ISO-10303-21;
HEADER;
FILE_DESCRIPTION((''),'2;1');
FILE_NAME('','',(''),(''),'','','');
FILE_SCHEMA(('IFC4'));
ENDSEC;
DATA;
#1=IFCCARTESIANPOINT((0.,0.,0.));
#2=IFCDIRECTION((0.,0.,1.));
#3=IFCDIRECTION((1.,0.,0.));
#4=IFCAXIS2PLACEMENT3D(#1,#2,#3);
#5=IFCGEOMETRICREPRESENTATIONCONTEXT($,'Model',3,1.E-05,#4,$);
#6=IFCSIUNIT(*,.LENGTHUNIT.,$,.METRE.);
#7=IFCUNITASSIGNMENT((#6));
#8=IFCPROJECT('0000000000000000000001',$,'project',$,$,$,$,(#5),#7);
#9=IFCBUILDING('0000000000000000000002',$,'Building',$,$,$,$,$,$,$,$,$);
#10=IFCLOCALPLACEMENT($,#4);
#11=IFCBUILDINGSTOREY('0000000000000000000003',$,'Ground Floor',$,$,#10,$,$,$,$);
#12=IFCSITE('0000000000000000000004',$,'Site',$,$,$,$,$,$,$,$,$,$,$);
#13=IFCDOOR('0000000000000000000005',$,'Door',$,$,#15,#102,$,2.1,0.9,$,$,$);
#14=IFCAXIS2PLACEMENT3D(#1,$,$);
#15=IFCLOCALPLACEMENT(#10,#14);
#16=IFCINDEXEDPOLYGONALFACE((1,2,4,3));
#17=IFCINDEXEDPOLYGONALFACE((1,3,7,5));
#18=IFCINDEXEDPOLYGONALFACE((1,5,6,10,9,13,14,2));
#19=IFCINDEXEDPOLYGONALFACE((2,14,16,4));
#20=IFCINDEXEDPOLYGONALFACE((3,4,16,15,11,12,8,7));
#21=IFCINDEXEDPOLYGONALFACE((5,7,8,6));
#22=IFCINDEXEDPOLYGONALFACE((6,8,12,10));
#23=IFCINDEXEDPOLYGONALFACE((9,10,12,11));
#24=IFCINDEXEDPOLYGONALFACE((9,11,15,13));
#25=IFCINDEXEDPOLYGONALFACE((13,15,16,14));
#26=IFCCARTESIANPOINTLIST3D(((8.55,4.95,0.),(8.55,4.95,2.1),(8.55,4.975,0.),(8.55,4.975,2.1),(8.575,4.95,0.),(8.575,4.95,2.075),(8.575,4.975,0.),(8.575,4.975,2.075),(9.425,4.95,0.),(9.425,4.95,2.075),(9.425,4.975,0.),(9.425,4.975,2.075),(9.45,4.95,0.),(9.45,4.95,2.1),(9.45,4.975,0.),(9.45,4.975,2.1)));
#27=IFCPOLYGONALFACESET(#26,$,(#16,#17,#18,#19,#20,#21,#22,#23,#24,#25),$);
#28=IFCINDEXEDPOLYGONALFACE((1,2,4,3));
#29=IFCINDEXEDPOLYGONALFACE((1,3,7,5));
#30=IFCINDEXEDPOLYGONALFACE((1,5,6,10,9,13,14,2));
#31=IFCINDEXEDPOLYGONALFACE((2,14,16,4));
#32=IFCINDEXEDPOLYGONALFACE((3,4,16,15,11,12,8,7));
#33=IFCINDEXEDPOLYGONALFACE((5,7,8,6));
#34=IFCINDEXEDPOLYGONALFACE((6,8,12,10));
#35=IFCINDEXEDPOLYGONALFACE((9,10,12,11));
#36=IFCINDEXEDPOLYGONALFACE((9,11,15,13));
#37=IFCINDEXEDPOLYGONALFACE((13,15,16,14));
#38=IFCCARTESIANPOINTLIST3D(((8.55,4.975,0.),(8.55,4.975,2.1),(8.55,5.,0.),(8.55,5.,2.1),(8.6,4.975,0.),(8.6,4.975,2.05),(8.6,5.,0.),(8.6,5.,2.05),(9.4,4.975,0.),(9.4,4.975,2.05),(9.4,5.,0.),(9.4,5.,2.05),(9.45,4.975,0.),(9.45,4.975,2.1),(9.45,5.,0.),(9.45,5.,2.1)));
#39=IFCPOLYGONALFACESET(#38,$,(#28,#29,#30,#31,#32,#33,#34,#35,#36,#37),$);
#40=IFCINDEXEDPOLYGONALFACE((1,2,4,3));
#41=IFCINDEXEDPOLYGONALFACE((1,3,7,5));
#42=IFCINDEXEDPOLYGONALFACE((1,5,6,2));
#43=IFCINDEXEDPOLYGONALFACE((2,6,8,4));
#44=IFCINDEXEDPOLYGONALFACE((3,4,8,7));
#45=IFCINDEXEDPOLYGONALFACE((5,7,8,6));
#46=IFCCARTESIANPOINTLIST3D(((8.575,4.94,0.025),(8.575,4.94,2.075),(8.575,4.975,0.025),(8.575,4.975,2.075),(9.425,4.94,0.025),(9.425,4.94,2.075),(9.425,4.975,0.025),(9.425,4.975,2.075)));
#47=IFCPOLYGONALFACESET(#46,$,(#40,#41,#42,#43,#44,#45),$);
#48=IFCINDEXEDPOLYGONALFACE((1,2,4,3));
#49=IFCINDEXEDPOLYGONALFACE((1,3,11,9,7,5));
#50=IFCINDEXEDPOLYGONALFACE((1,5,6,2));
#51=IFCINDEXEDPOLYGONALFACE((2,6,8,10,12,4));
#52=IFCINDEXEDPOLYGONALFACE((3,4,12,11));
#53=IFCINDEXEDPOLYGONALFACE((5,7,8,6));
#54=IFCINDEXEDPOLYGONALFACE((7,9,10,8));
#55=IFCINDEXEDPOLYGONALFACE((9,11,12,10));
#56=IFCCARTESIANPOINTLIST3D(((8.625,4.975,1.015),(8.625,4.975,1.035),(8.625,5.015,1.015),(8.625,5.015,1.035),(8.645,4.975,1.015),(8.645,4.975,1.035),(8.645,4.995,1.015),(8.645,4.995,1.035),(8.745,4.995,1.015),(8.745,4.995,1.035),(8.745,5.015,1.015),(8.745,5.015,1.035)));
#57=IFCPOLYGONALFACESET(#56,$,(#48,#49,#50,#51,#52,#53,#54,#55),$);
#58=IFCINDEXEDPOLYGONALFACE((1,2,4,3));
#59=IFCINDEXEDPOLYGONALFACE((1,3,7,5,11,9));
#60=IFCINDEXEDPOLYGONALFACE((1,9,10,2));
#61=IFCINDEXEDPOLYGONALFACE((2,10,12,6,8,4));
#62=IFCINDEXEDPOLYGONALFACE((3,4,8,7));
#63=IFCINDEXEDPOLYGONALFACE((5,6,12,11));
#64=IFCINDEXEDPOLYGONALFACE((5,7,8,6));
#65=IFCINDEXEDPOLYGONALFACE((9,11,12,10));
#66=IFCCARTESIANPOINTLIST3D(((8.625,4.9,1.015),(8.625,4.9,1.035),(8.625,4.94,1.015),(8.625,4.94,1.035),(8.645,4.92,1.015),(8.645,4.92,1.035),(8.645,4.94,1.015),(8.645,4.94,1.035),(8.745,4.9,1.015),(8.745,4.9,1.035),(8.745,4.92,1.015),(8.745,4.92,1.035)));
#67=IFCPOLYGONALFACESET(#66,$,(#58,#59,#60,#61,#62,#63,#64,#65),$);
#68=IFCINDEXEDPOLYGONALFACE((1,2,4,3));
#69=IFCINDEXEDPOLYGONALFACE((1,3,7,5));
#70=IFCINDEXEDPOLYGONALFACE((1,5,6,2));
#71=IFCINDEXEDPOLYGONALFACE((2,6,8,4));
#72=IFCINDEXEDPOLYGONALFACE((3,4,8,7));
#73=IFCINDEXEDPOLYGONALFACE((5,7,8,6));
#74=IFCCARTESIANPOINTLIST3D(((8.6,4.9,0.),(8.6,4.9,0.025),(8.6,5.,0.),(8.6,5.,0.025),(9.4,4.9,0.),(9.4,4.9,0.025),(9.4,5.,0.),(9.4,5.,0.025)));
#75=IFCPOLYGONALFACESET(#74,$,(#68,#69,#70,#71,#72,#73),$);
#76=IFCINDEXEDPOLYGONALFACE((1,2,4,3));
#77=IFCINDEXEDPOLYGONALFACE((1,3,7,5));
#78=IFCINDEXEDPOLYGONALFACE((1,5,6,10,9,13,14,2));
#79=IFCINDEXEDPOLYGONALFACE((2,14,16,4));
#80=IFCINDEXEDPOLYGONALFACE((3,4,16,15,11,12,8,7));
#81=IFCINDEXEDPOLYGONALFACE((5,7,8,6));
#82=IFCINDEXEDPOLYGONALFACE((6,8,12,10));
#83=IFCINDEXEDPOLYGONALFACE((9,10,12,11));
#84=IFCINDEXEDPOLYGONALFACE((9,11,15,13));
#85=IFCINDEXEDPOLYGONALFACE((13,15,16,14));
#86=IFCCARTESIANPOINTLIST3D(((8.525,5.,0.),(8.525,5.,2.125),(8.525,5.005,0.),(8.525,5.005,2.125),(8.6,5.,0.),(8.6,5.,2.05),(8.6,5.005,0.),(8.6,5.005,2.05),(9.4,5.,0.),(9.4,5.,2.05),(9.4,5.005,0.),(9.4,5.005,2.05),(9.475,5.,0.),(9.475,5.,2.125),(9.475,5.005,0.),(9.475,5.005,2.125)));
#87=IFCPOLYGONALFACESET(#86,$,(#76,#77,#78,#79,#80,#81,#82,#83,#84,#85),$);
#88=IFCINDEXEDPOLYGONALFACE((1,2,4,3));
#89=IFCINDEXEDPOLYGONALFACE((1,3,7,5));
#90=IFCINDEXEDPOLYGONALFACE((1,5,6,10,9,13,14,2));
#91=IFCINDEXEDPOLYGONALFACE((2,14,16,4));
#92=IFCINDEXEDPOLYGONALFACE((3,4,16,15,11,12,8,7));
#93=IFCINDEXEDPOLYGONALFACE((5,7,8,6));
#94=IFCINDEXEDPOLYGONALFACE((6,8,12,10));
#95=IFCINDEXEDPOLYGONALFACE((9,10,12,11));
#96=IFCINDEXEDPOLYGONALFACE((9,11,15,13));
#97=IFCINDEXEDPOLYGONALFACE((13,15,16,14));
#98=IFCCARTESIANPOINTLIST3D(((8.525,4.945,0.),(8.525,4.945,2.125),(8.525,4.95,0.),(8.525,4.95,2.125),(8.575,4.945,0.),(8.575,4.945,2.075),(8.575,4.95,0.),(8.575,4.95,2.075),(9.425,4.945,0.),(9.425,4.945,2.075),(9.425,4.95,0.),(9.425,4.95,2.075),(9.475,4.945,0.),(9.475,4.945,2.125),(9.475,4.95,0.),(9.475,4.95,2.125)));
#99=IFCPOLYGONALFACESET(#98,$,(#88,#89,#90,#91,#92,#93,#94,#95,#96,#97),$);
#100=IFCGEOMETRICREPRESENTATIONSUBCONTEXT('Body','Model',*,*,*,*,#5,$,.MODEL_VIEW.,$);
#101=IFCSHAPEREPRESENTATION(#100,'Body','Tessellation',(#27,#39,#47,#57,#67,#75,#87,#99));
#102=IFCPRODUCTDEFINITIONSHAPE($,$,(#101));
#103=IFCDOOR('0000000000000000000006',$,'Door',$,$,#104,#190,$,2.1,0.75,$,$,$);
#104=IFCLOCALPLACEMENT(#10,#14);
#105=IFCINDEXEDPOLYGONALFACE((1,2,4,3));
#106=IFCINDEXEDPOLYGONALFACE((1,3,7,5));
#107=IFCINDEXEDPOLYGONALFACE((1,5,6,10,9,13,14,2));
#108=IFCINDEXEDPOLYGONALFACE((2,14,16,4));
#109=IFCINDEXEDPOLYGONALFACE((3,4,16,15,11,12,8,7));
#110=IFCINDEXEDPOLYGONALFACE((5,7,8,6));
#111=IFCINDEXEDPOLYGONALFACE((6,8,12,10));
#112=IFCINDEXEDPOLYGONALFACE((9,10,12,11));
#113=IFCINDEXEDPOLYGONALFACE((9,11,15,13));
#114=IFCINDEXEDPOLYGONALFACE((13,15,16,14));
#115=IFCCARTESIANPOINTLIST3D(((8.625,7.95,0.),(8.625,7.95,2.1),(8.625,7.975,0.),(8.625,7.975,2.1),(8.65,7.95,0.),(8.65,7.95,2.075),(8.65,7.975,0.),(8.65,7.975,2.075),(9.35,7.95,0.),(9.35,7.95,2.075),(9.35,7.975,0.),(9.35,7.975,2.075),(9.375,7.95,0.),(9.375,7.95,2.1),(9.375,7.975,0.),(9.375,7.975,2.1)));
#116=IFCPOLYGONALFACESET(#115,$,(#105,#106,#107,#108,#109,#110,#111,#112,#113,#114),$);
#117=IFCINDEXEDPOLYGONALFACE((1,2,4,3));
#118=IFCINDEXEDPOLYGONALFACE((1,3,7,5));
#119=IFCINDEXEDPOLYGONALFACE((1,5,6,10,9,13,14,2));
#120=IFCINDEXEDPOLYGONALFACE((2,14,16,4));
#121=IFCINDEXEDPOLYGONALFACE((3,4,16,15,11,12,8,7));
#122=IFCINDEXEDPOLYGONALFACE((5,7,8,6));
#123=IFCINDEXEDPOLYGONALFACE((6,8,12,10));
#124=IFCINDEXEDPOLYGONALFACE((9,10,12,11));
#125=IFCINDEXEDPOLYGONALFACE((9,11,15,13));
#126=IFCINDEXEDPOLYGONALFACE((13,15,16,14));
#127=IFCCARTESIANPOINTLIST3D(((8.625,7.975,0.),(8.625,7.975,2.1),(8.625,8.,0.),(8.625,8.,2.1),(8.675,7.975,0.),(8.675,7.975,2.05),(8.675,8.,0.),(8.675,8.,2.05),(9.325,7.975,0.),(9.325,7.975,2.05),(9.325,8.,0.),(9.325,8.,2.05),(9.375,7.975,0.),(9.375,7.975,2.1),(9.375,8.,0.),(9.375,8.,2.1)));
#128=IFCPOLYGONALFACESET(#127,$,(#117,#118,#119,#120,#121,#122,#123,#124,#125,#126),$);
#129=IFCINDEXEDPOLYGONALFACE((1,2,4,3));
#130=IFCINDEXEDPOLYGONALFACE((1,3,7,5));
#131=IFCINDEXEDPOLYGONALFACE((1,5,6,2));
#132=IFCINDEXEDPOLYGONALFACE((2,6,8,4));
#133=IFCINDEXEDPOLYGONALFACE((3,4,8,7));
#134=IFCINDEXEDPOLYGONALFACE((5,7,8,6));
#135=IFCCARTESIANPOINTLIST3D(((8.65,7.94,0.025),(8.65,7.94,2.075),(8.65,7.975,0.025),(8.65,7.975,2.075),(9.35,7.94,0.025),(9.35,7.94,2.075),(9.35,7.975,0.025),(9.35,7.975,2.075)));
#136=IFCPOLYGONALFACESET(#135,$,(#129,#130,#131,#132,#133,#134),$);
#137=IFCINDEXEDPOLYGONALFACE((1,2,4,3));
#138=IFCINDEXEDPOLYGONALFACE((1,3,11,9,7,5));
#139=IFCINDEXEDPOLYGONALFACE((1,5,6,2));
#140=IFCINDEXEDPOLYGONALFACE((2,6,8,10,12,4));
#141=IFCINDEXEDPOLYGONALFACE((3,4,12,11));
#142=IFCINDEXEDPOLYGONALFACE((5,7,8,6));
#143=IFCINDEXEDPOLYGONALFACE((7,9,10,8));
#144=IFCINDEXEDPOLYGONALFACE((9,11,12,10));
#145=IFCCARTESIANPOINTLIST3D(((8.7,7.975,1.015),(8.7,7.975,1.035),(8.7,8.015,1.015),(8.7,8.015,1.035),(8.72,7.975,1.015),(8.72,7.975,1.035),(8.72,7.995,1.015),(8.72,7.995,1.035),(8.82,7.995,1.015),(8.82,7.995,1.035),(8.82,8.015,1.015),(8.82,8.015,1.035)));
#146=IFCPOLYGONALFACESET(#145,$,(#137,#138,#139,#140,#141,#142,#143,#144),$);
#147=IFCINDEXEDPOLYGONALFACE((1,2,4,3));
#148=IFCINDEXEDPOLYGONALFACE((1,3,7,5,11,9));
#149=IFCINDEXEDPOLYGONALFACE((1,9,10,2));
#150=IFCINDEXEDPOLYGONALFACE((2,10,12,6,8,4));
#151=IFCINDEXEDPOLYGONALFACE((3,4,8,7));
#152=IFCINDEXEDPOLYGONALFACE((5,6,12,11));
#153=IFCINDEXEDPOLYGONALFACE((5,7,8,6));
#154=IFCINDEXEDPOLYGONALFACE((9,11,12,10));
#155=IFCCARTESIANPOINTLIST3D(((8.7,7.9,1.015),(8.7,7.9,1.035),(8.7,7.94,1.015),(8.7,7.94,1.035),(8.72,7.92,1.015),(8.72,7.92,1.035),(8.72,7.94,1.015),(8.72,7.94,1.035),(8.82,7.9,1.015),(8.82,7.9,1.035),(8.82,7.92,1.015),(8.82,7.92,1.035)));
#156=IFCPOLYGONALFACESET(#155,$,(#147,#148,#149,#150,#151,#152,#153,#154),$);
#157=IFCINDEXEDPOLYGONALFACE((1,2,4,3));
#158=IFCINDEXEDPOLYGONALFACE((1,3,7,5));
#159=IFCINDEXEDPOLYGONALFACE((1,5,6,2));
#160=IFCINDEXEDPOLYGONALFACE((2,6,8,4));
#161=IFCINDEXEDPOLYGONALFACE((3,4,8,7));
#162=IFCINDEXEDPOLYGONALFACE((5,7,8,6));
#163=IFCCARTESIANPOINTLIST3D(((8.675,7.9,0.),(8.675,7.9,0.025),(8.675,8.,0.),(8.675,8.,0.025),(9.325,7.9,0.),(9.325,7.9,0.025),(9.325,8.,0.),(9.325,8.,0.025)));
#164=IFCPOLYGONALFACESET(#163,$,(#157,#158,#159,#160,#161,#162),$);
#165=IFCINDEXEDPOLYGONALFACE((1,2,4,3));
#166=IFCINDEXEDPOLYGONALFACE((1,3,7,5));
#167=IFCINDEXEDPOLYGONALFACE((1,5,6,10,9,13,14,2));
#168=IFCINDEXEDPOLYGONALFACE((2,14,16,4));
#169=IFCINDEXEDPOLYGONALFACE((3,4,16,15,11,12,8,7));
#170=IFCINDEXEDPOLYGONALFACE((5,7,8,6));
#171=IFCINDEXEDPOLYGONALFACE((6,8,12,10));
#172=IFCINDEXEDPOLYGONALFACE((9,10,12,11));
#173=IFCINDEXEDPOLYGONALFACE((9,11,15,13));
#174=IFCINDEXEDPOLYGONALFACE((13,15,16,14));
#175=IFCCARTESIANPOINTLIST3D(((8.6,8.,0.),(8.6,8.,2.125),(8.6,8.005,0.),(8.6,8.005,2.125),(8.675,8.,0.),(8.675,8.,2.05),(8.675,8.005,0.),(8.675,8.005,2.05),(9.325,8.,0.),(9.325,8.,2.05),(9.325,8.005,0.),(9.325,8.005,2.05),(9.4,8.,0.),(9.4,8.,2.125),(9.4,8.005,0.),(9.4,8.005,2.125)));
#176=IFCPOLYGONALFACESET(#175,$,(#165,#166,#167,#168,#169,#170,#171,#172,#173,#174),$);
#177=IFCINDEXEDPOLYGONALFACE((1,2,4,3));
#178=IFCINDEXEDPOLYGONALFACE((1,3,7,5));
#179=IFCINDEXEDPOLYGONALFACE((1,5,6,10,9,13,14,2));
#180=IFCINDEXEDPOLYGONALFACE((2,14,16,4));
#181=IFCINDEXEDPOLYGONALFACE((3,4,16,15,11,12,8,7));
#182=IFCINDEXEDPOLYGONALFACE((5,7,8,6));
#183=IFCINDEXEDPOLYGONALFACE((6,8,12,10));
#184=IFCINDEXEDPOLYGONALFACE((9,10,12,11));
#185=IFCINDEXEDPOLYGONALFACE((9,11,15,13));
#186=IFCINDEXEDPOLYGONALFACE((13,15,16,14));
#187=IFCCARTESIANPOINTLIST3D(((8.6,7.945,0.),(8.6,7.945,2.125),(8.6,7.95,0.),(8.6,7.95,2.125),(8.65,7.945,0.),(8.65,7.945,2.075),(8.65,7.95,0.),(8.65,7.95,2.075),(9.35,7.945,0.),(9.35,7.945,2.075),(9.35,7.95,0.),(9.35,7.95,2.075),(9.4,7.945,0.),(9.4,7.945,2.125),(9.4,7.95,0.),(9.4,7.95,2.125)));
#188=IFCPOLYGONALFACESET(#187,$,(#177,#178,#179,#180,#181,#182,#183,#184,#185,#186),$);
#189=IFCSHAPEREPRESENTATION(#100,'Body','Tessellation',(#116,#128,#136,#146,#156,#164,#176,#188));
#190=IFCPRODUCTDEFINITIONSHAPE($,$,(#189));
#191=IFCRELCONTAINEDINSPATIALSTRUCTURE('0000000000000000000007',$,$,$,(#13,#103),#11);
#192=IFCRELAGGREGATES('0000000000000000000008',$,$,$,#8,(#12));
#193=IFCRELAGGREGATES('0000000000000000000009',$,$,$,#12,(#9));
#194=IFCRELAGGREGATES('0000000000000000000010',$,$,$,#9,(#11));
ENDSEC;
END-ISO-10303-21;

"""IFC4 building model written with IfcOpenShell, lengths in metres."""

from ifc_helpers import new_model, si_unit, frame, origin_with_axes, place, context, subcontext, project, spatial, line, indexed_curve, outline, extrude, element, save


model = new_model("IFC4")

# Units and contexts
model_context = context("Model", 3, precision=1e-05, world=origin_with_axes())
body_context = subcontext(model_context, "Body", "Model", "MODEL_VIEW")
ifc_project = project(units=[si_unit("LENGTHUNIT", "METRE")], contexts=[model_context])

# Site, building, storey
site = spatial("IfcSite", under=ifc_project, Name="Site")
building = spatial("IfcBuilding", under=site, Name="Building")
storey_placement = place(None, origin_with_axes())
storey = spatial("IfcBuildingStorey", under=building, at=storey_placement, Name="Ground Floor")

# Doors
door_1_placement = place(storey_placement, frame((9.45, 5.0, 0.0), z_axis=(0.0, 0.0, 1.0), x_axis=(-1.0, 0.0, 0.0)))
element("IfcDoor", 1, at=door_1_placement, inside=storey, Name="Door", OverallHeight=2.1, OverallWidth=0.9, context=body_context, shape_type="SweptSolid", body=[
    extrude(outline(indexed_curve([(0.0, 0.0), (0.0, 2.1), (0.9, 2.1), (0.9, 0.0), (0.875, 0.0), (0.875, 2.075), (0.025, 2.075), (0.025, 0.0)], segments=[line(1, 2, 3, 4, 5, 6, 7, 8, 1)])), frame((0.0, 0.025, 0.0), z_axis=(0.0, -1.0, 0.0), x_axis=(1.0, 0.0, 0.0)), (0.0, 0.0, -1.0), 0.025),
    extrude(outline(indexed_curve([(0.0, 0.0), (0.0, 2.1), (0.9, 2.1), (0.9, 0.0), (0.85, 0.0), (0.85, 2.05), (0.05, 2.05), (0.05, 0.0)], segments=[line(1, 2, 3, 4, 5, 6, 7, 8, 1)])), frame((0.0, 0.0, 0.0), z_axis=(0.0, -1.0, 0.0), x_axis=(1.0, 0.0, 0.0)), (0.0, 0.0, -1.0), 0.025),
    extrude(outline(indexed_curve([(0.0, 0.0), (0.85, 0.0), (0.85, 0.035), (0.0, 0.035)], segments=[line(1, 2, 3, 4, 1)])), frame((0.025, 0.025, 0.025), z_axis=(0.0, 0.0, 1.0), x_axis=(1.0, 0.0, 0.0)), (0.0, 0.0, 1.0), 2.05),
    extrude(outline(indexed_curve([(0.0, 0.0), (0.0, -0.04), (-0.12, -0.04), (-0.12, -0.02), (-0.02, -0.02), (-0.02, 0.0)], segments=[line(1, 2, 3, 4, 5, 6, 1)])), frame((0.825, 0.025, 1.015), z_axis=(0.0, 0.0, 1.0), x_axis=(1.0, 0.0, 0.0)), (0.0, 0.0, 1.0), 0.02),
    extrude(outline(indexed_curve([(0.0, 0.0), (0.0, 0.04), (-0.12, 0.04), (-0.12, 0.02), (-0.02, 0.02), (-0.02, 0.0)], segments=[line(1, 2, 3, 4, 5, 6, 1)])), frame((0.825, 0.06, 1.015), z_axis=(0.0, 0.0, 1.0), x_axis=(1.0, 0.0, 0.0)), (0.0, 0.0, 1.0), 0.02),
    extrude(outline(indexed_curve([(0.0, 0.0), (0.8, 0.0), (0.8, 0.1), (0.0, 0.1)], segments=[line(1, 2, 3, 4, 1)])), frame((0.05, 0.0, 0.0), z_axis=(0.0, 0.0, 1.0), x_axis=(1.0, 0.0, 0.0)), (0.0, 0.0, 1.0), 0.025),
    extrude(outline(indexed_curve([(0.0, 0.0), (0.0, 2.125), (0.95, 2.125), (0.95, 0.0), (0.875, 0.0), (0.875, 2.05), (0.075, 2.05), (0.075, 0.0)], segments=[line(1, 2, 3, 4, 5, 6, 7, 8, 1)])), frame((-0.025, -0.005, 0.0), z_axis=(0.0, -1.0, 0.0), x_axis=(1.0, 0.0, 0.0)), (0.0, 0.0, -1.0), 0.005),
    extrude(outline(indexed_curve([(0.0, 0.0), (0.0, 2.125), (0.95, 2.125), (0.95, 0.0), (0.9, 0.0), (0.9, 2.075), (0.05, 2.075), (0.05, 0.0)], segments=[line(1, 2, 3, 4, 5, 6, 7, 8, 1)])), frame((-0.025, 0.05, 0.0), z_axis=(0.0, -1.0, 0.0), x_axis=(1.0, 0.0, 0.0)), (0.0, 0.0, -1.0), 0.005),
])
door_2_placement = place(storey_placement, frame((9.375, 8.0, 0.0), z_axis=(0.0, 0.0, 1.0), x_axis=(-1.0, 0.0, 0.0)))
element("IfcDoor", 2, at=door_2_placement, inside=storey, Name="Door", OverallHeight=2.1, OverallWidth=0.75, context=body_context, shape_type="SweptSolid", body=[
    extrude(outline(indexed_curve([(0.0, 0.0), (0.0, 2.1), (0.75, 2.1), (0.75, 0.0), (0.725, 0.0), (0.725, 2.075), (0.025, 2.075), (0.025, 0.0)], segments=[line(1, 2, 3, 4, 5, 6, 7, 8, 1)])), frame((0.0, 0.025, 0.0), z_axis=(0.0, -1.0, 0.0), x_axis=(1.0, 0.0, 0.0)), (0.0, 0.0, -1.0), 0.025),
    extrude(outline(indexed_curve([(0.0, 0.0), (0.0, 2.1), (0.75, 2.1), (0.75, 0.0), (0.7, 0.0), (0.7, 2.05), (0.05, 2.05), (0.05, 0.0)], segments=[line(1, 2, 3, 4, 5, 6, 7, 8, 1)])), frame((0.0, 0.0, 0.0), z_axis=(0.0, -1.0, 0.0), x_axis=(1.0, 0.0, 0.0)), (0.0, 0.0, -1.0), 0.025),
    extrude(outline(indexed_curve([(0.0, 0.0), (0.7, 0.0), (0.7, 0.035), (0.0, 0.035)], segments=[line(1, 2, 3, 4, 1)])), frame((0.025, 0.025, 0.025), z_axis=(0.0, 0.0, 1.0), x_axis=(1.0, 0.0, 0.0)), (0.0, 0.0, 1.0), 2.05),
    extrude(outline(indexed_curve([(0.0, 0.0), (0.0, -0.04), (-0.12, -0.04), (-0.12, -0.02), (-0.02, -0.02), (-0.02, 0.0)], segments=[line(1, 2, 3, 4, 5, 6, 1)])), frame((0.675, 0.025, 1.015), z_axis=(0.0, 0.0, 1.0), x_axis=(1.0, 0.0, 0.0)), (0.0, 0.0, 1.0), 0.02),
    extrude(outline(indexed_curve([(0.0, 0.0), (0.0, 0.04), (-0.12, 0.04), (-0.12, 0.02), (-0.02, 0.02), (-0.02, 0.0)], segments=[line(1, 2, 3, 4, 5, 6, 1)])), frame((0.675, 0.06, 1.015), z_axis=(0.0, 0.0, 1.0), x_axis=(1.0, 0.0, 0.0)), (0.0, 0.0, 1.0), 0.02),
    extrude(outline(indexed_curve([(0.0, 0.0), (0.65, 0.0), (0.65, 0.1), (0.0, 0.1)], segments=[line(1, 2, 3, 4, 1)])), frame((0.05, 0.0, 0.0), z_axis=(0.0, 0.0, 1.0), x_axis=(1.0, 0.0, 0.0)), (0.0, 0.0, 1.0), 0.025),
    extrude(outline(indexed_curve([(0.0, 0.0), (0.0, 2.125), (0.8, 2.125), (0.8, 0.0), (0.725, 0.0), (0.725, 2.05), (0.075, 2.05), (0.075, 0.0)], segments=[line(1, 2, 3, 4, 5, 6, 7, 8, 1)])), frame((-0.025, -0.005, 0.0), z_axis=(0.0, -1.0, 0.0), x_axis=(1.0, 0.0, 0.0)), (0.0, 0.0, -1.0), 0.005),
    extrude(outline(indexed_curve([(0.0, 0.0), (0.0, 2.125), (0.8, 2.125), (0.8, 0.0), (0.75, 0.0), (0.75, 2.075), (0.05, 2.075), (0.05, 0.0)], segments=[line(1, 2, 3, 4, 5, 6, 7, 8, 1)])), frame((-0.025, 0.05, 0.0), z_axis=(0.0, -1.0, 0.0), x_axis=(1.0, 0.0, 0.0)), (0.0, 0.0, -1.0), 0.005),
])

save(model, "model.ifc")
